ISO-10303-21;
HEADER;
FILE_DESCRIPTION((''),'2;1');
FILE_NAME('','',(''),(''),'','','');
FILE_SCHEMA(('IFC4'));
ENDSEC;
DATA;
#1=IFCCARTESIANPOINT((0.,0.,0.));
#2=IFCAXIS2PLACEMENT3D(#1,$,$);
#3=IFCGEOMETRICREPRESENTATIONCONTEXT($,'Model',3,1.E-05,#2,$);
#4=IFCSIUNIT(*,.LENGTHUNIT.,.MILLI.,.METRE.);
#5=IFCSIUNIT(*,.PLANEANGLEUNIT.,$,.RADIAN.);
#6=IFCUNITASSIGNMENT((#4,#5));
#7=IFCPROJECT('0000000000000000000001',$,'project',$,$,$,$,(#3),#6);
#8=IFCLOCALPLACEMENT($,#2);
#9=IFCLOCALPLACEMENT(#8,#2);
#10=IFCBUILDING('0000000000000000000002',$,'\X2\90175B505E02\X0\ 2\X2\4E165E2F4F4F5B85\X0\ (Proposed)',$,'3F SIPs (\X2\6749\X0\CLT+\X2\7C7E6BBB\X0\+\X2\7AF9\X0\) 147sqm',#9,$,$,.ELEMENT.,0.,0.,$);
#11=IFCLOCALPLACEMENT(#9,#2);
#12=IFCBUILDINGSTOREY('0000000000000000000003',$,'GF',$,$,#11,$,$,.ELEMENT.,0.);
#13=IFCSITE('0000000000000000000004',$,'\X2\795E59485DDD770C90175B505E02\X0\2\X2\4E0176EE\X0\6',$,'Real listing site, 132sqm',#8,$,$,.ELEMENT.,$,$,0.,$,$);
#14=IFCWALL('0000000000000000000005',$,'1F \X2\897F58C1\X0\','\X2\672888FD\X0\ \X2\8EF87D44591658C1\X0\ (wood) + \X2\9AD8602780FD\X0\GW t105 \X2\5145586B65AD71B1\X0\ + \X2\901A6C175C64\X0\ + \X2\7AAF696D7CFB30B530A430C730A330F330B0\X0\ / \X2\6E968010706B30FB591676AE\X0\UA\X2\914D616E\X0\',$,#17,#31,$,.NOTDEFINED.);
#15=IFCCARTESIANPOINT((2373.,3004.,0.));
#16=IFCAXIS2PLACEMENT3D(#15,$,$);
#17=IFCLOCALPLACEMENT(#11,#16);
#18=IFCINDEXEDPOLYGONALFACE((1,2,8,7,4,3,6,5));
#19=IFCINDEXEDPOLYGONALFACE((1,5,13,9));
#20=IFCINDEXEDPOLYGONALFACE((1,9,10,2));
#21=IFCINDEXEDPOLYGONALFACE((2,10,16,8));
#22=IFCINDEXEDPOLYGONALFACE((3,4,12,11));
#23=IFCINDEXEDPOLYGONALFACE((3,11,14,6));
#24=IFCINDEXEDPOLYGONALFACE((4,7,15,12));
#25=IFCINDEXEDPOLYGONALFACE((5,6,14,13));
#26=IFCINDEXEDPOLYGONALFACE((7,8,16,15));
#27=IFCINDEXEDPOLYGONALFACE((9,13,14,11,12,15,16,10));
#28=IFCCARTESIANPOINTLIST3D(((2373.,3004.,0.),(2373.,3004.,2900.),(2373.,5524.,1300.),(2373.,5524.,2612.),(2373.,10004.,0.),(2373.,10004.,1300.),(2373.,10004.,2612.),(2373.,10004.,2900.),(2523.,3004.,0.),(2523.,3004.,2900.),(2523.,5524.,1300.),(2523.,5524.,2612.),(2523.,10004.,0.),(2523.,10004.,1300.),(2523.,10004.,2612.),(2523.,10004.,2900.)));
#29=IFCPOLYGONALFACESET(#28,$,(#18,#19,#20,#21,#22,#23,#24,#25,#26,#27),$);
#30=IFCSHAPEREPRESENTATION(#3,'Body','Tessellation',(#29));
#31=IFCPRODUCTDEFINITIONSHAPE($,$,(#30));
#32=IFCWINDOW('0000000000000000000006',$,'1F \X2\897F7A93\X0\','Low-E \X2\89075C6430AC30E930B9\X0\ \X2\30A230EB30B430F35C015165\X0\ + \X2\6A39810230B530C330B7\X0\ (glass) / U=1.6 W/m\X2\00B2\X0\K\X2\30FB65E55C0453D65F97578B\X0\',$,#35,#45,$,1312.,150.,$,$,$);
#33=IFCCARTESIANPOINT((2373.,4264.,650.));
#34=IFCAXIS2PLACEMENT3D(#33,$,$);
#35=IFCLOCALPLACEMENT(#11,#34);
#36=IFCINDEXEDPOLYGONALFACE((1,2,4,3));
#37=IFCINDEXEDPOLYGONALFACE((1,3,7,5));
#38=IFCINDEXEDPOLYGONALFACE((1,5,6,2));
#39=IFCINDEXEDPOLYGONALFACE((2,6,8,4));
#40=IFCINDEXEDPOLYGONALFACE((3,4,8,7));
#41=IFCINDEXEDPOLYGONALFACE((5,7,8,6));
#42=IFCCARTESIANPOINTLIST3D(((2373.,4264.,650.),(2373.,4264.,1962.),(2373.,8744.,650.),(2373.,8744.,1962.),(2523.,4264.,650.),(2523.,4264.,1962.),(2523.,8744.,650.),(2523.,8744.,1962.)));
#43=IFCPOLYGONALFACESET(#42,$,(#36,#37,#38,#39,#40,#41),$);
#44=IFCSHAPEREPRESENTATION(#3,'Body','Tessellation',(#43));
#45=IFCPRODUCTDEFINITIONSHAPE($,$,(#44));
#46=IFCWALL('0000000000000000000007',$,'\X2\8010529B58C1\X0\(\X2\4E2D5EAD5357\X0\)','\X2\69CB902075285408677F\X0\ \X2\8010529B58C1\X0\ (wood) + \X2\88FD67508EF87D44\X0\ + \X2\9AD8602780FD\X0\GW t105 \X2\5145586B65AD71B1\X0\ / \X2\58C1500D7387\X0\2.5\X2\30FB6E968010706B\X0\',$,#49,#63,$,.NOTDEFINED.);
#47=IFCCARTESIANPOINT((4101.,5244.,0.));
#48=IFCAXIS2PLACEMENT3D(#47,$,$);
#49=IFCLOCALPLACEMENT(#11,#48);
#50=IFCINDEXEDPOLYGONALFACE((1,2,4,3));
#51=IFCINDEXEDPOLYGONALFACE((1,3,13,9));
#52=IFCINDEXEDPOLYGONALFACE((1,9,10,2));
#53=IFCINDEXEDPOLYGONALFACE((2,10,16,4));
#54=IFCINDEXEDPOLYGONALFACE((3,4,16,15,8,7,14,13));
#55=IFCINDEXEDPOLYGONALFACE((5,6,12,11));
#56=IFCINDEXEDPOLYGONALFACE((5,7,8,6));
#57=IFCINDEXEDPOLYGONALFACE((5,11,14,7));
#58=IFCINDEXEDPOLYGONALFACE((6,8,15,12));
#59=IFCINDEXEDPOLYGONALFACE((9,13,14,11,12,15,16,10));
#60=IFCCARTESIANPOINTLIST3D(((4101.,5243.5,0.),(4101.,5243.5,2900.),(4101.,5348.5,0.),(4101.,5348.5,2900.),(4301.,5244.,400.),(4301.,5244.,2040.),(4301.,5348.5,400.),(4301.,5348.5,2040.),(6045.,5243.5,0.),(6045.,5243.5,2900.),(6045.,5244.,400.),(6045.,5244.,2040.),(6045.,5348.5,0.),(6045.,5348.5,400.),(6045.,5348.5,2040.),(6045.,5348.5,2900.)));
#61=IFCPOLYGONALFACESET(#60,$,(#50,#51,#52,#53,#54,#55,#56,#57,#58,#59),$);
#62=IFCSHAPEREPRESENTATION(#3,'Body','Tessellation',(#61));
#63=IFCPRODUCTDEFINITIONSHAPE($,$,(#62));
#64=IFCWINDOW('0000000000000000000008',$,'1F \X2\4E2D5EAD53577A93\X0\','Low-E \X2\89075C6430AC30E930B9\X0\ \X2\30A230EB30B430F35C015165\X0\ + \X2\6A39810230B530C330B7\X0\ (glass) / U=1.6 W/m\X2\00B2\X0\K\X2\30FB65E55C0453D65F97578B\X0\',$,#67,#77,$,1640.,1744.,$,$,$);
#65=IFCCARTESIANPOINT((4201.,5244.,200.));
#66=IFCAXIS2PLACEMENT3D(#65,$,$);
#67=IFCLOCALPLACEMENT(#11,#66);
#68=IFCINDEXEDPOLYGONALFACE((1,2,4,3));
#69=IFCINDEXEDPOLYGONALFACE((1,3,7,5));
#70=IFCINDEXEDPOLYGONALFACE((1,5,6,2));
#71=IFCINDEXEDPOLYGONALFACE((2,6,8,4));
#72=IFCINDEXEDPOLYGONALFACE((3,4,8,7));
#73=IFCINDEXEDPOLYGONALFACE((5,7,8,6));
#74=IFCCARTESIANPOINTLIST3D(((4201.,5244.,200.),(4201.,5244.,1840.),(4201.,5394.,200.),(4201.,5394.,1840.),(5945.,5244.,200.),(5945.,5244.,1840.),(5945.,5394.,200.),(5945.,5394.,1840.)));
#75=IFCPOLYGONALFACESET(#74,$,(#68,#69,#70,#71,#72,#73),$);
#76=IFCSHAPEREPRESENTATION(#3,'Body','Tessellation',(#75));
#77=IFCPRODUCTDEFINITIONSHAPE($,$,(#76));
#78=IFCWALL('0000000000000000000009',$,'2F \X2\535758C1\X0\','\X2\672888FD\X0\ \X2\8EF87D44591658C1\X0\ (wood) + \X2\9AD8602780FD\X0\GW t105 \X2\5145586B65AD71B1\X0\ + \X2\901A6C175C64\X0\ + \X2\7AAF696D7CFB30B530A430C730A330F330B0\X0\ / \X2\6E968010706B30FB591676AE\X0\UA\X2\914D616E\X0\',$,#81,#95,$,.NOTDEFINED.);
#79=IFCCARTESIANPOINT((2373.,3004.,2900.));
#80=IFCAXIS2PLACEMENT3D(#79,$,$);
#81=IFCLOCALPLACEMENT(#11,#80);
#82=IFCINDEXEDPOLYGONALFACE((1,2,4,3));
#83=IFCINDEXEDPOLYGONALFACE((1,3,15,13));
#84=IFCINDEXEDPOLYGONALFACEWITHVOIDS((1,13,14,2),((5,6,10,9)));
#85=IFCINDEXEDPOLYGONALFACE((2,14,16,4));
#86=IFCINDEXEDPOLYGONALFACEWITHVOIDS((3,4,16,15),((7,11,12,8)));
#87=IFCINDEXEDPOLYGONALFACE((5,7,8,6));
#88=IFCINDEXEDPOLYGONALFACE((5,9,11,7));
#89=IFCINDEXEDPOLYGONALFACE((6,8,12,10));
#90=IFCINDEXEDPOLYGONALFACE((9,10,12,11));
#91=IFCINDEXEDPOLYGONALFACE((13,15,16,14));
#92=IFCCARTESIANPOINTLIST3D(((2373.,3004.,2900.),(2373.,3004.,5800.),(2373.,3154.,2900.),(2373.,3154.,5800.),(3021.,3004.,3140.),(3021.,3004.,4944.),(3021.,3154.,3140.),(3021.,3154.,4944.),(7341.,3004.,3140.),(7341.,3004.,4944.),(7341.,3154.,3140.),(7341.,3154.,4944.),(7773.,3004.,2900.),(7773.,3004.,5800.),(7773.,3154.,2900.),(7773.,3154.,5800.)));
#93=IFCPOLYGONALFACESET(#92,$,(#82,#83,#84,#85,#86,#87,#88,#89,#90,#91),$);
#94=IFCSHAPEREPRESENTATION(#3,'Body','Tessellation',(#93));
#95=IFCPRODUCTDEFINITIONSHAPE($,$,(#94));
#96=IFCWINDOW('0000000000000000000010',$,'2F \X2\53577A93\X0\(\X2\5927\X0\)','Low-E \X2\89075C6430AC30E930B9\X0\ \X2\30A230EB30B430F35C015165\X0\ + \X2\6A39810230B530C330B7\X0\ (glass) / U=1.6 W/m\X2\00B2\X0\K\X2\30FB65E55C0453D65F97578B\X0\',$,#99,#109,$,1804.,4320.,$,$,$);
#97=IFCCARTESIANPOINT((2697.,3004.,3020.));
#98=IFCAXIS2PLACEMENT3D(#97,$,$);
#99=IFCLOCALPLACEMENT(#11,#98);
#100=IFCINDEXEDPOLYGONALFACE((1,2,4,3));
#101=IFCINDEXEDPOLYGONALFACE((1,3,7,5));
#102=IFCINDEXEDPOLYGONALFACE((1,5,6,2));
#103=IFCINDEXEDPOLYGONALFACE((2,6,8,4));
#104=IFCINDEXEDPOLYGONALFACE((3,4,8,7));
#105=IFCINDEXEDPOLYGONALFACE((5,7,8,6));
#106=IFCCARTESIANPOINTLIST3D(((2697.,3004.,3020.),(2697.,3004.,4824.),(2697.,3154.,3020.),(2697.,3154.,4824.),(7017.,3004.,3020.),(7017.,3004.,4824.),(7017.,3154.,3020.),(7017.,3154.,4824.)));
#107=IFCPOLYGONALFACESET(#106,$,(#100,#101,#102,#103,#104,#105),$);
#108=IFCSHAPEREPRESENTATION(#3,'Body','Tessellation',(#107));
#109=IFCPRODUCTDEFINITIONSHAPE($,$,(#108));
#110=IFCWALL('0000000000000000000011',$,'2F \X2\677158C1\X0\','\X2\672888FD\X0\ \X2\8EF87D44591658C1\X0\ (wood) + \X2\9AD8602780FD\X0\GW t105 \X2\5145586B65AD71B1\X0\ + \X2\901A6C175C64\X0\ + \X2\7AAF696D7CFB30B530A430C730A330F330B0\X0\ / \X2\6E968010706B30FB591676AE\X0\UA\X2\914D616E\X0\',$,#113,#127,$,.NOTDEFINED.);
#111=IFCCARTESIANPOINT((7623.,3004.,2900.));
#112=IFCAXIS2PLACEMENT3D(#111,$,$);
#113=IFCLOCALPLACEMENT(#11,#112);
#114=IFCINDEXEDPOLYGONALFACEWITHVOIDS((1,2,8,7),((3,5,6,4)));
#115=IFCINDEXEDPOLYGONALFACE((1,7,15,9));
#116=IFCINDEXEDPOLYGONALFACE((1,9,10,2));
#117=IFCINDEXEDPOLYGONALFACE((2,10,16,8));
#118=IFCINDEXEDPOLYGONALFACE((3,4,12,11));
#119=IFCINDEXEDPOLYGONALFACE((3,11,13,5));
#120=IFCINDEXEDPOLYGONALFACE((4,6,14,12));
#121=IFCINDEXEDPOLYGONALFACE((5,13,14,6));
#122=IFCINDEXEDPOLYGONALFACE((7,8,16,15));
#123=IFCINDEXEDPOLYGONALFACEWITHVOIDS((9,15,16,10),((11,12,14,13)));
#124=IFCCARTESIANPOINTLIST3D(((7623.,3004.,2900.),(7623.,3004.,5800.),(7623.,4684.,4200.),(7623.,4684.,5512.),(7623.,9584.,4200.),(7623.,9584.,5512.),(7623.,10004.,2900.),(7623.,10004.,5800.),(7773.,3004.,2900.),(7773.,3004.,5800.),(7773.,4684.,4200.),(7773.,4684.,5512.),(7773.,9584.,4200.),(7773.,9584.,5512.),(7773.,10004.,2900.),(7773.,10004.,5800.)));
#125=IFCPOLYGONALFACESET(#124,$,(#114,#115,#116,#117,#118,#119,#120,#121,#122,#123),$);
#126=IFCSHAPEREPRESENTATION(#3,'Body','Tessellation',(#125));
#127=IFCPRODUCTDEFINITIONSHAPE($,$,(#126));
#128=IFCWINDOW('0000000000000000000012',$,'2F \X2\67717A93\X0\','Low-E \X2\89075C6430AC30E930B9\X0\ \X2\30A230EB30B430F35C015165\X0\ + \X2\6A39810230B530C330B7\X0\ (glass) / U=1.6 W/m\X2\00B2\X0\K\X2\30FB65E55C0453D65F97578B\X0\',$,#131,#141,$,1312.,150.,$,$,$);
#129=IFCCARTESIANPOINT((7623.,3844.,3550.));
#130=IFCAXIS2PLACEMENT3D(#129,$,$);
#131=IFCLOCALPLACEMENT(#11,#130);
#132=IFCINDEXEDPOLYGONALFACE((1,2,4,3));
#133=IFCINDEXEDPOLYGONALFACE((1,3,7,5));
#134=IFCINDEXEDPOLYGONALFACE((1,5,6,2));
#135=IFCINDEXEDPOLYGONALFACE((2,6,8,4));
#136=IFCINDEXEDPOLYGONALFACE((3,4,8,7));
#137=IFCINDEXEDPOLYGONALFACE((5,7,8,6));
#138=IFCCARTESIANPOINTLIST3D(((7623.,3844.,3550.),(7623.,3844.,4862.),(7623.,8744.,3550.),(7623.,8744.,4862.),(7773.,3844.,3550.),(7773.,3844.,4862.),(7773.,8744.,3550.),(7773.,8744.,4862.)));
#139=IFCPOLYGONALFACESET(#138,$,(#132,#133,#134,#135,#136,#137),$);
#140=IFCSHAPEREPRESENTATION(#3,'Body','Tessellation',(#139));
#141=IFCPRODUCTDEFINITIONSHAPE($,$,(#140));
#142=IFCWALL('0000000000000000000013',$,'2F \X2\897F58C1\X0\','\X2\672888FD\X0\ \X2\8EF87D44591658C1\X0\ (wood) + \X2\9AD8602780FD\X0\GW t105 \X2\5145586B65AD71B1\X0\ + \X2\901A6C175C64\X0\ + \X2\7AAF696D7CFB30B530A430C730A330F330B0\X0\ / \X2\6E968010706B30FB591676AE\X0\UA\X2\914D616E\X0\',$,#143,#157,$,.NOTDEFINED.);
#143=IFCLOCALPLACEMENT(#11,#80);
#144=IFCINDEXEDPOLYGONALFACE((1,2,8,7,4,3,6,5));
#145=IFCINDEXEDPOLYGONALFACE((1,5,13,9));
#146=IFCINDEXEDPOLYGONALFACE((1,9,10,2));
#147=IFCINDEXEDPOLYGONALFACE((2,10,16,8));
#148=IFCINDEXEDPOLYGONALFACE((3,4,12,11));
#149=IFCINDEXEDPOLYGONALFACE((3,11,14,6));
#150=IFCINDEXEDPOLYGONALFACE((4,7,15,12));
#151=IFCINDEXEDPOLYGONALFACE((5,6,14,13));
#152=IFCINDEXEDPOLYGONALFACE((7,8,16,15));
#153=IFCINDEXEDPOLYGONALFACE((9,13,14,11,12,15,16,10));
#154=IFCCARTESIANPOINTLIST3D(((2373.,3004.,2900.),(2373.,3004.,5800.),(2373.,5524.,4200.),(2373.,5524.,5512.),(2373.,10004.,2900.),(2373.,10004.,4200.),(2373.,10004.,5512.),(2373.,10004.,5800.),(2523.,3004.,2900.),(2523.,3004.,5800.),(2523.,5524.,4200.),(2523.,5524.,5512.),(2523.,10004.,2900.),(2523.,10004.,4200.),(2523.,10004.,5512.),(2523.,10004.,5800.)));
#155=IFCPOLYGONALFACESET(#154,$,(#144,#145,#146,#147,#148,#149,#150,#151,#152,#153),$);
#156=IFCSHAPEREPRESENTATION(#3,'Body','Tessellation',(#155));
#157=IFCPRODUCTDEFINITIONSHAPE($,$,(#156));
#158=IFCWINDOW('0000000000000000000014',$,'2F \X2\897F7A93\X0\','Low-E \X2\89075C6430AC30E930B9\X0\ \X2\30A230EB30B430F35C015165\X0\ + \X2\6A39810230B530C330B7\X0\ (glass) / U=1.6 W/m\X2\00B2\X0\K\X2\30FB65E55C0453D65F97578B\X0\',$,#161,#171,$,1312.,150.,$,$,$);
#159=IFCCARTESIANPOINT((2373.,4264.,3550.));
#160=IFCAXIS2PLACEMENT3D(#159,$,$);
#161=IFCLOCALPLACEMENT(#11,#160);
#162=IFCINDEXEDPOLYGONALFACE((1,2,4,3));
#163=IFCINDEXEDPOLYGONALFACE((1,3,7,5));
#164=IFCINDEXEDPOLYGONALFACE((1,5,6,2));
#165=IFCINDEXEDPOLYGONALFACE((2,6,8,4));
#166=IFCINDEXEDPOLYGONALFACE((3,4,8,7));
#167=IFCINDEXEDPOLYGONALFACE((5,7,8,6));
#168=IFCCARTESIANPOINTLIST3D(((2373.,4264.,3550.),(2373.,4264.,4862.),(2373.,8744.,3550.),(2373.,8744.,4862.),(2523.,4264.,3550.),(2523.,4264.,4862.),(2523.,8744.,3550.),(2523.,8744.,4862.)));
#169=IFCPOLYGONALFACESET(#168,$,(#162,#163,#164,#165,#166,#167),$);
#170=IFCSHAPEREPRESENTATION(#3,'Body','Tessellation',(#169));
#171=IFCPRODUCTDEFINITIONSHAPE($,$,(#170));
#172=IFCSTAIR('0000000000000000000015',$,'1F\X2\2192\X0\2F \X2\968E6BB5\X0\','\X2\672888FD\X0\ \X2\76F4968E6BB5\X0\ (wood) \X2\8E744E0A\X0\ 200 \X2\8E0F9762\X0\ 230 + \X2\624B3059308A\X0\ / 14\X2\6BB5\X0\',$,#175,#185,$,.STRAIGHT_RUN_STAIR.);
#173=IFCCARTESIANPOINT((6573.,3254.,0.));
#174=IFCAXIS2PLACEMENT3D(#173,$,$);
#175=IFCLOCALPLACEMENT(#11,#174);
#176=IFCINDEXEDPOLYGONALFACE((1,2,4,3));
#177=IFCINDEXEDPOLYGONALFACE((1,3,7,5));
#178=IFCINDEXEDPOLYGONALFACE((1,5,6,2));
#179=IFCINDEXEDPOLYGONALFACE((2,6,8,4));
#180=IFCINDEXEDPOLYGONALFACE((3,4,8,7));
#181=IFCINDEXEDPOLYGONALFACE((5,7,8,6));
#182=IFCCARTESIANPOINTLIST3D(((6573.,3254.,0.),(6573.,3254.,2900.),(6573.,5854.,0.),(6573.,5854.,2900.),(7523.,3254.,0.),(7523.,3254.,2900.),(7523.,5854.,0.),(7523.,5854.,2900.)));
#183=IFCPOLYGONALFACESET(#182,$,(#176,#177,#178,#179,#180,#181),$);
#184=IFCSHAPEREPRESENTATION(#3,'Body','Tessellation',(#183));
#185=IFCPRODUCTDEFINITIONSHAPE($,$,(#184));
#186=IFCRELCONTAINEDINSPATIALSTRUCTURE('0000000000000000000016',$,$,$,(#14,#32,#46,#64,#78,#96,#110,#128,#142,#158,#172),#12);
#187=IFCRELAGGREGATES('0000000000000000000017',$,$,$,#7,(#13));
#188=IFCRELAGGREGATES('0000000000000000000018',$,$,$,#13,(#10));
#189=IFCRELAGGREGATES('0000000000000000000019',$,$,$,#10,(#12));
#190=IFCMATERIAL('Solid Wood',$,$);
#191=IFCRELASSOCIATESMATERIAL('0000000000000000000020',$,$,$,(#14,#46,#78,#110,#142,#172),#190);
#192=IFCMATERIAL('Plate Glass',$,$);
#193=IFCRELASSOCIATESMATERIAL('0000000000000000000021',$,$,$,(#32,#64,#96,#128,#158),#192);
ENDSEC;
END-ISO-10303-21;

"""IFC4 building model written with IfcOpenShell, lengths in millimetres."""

from ifc_helpers import new_model, si_unit, frame, frame_2d, origin, place, context, project, spatial, rectangle, extrude, material, element, fill, save


model = new_model("IFC4")

# Units and contexts
model_context = context("Model", 3, precision=1e-05, world=origin())
ifc_project = project(units=[si_unit("LENGTHUNIT", "METRE", prefix="MILLI"), si_unit("PLANEANGLEUNIT", "RADIAN")], contexts=[model_context])

# Site, building, storey
site_placement = place(None, origin())
site = spatial("IfcSite", under=ifc_project, at=site_placement, Name="神奈川県逗子市2丁目6", ObjectType="Real listing site, 132sqm", CompositionType="ELEMENT", RefElevation=0.0)
building_placement = place(site_placement, origin())
building = spatial("IfcBuilding", under=site, at=building_placement, Name="逗子市 2世帯住宅 (Proposed)", ObjectType="3F SIPs (杉CLT+籾殻+竹) 147sqm", CompositionType="ELEMENT", ElevationOfRefHeight=0.0, ElevationOfTerrain=0.0)
storey_placement = place(building_placement, origin())
storey = spatial("IfcBuildingStorey", under=building, at=storey_placement, Name="GF", CompositionType="ELEMENT", Elevation=0.0)

# Shared definitions
ifc_material_1 = material(Name="Solid Wood")

# Shared definitions
ifc_material_2 = material(Name="Plate Glass")

# Walls, openings, windows
wall_1_placement = place(storey_placement, frame((2373.0, 3004.0, 0.0)))
wall_1 = element("IfcWall", 1, at=wall_1_placement, inside=storey, material=ifc_material_1, Name="1F 西壁", Description="木製 軸組外壁 (wood) + 高性能GW t105 充填断熱 + 通気層 + 窯業系サイディング / 準耐火・外皮UA配慮", PredefinedType="NOTDEFINED", context=model_context, shape_type="SweptSolid", body=[
    extrude(rectangle(XDim=150.0, YDim=7000.0, at=frame_2d((75.0, 3500.0))), frame((2373.0, 3004.0, 0.0)), (0.0, 0.0, 1.0), 2900.0),
])
opening_1_placement = place(storey_placement, frame((2373.0, 4264.0, 650.0)))
opening_1 = element("IfcOpeningElement", 2, at=opening_1_placement, cuts=wall_1, PredefinedType="NOTDEFINED", context=model_context, shape_type="SweptSolid", body=[
    extrude(rectangle(XDim=150.0, YDim=4480.0, at=frame_2d((75.0, 2240.0))), frame((2373.0, 4264.0, 650.0)), (0.0, 0.0, 1.0), 1312.0),
])
window_1_placement = place(storey_placement, frame((2373.0, 4264.0, 650.0)))
window_1 = element("IfcWindow", 3, at=window_1_placement, inside=storey, material=ifc_material_2, Name="1F 西窓", Description="Low-E 複層ガラス アルゴン封入 + 樹脂サッシ (glass) / U=1.6 W/m²K・日射取得型", OverallHeight=1312.0, OverallWidth=150.0, context=model_context, shape_type="SweptSolid", body=[
    extrude(rectangle(XDim=150.0, YDim=4480.0, at=frame_2d((75.0, 2240.0))), frame((2373.0, 4264.0, 650.0)), (0.0, 0.0, 1.0), 1312.0),
])
fill(opening_1, window_1)
wall_2_placement = place(storey_placement, frame((4101.0, 5244.0, 0.0)))
wall_2 = element("IfcWall", 4, at=wall_2_placement, inside=storey, material=ifc_material_1, Name="耐力壁(中庭南)", Description="構造用合板 耐力壁 (wood) + 製材軸組 + 高性能GW t105 充填断熱 / 壁倍率2.5・準耐火", PredefinedType="NOTDEFINED", context=model_context, shape_type="SweptSolid", body=[
    extrude(rectangle(XDim=1944.0, YDim=105.0, at=frame_2d((972.0, 52.0))), frame((4101.0, 5244.0, 0.0)), (0.0, 0.0, 1.0), 2900.0),
])
opening_2_placement = place(storey_placement, frame((4201.0, 5244.0, 200.0)))
opening_2 = element("IfcOpeningElement", 5, at=opening_2_placement, cuts=wall_2, PredefinedType="NOTDEFINED", context=model_context, shape_type="SweptSolid", body=[
    extrude(rectangle(XDim=1744.0, YDim=150.0, at=frame_2d((872.0, 75.0))), frame((4201.0, 5244.0, 200.0)), (0.0, 0.0, 1.0), 1640.0),
])
window_2_placement = place(storey_placement, frame((4201.0, 5244.0, 200.0)))
window_2 = element("IfcWindow", 6, at=window_2_placement, inside=storey, material=ifc_material_2, Name="1F 中庭南窓", Description="Low-E 複層ガラス アルゴン封入 + 樹脂サッシ (glass) / U=1.6 W/m²K・日射取得型", OverallHeight=1640.0, OverallWidth=1744.0, context=model_context, shape_type="SweptSolid", body=[
    extrude(rectangle(XDim=1744.0, YDim=150.0, at=frame_2d((872.0, 75.0))), frame((4201.0, 5244.0, 200.0)), (0.0, 0.0, 1.0), 1640.0),
])
fill(opening_2, window_2)
wall_3_placement = place(storey_placement, frame((2373.0, 3004.0, 2900.0)))
wall_3 = element("IfcWall", 7, at=wall_3_placement, inside=storey, material=ifc_material_1, Name="2F 南壁", Description="木製 軸組外壁 (wood) + 高性能GW t105 充填断熱 + 通気層 + 窯業系サイディング / 準耐火・外皮UA配慮", PredefinedType="NOTDEFINED", context=model_context, shape_type="SweptSolid", body=[
    extrude(rectangle(XDim=5400.0, YDim=150.0, at=frame_2d((2700.0, 75.0))), frame((2373.0, 3004.0, 2900.0)), (0.0, 0.0, 1.0), 2900.0),
])
opening_3_placement = place(storey_placement, frame((2697.0, 3004.0, 3020.0)))
opening_3 = element("IfcOpeningElement", 8, at=opening_3_placement, cuts=wall_3, PredefinedType="NOTDEFINED", context=model_context, shape_type="SweptSolid", body=[
    extrude(rectangle(XDim=4320.0, YDim=150.0, at=frame_2d((2160.0, 75.0))), frame((2697.0, 3004.0, 3020.0)), (0.0, 0.0, 1.0), 1804.0),
])
window_3_placement = place(storey_placement, frame((2697.0, 3004.0, 3020.0)))
window_3 = element("IfcWindow", 9, at=window_3_placement, inside=storey, material=ifc_material_2, Name="2F 南窓(大)", Description="Low-E 複層ガラス アルゴン封入 + 樹脂サッシ (glass) / U=1.6 W/m²K・日射取得型", OverallHeight=1804.0, OverallWidth=4320.0, context=model_context, shape_type="SweptSolid", body=[
    extrude(rectangle(XDim=4320.0, YDim=150.0, at=frame_2d((2160.0, 75.0))), frame((2697.0, 3004.0, 3020.0)), (0.0, 0.0, 1.0), 1804.0),
])
fill(opening_3, window_3)
wall_4_placement = place(storey_placement, frame((7623.0, 3004.0, 2900.0)))
wall_4 = element("IfcWall", 10, at=wall_4_placement, inside=storey, material=ifc_material_1, Name="2F 東壁", Description="木製 軸組外壁 (wood) + 高性能GW t105 充填断熱 + 通気層 + 窯業系サイディング / 準耐火・外皮UA配慮", PredefinedType="NOTDEFINED", context=model_context, shape_type="SweptSolid", body=[
    extrude(rectangle(XDim=150.0, YDim=7000.0, at=frame_2d((75.0, 3500.0))), frame((7623.0, 3004.0, 2900.0)), (0.0, 0.0, 1.0), 2900.0),
])
opening_4_placement = place(storey_placement, frame((7623.0, 3844.0, 3550.0)))
opening_4 = element("IfcOpeningElement", 11, at=opening_4_placement, cuts=wall_4, PredefinedType="NOTDEFINED", context=model_context, shape_type="SweptSolid", body=[
    extrude(rectangle(XDim=150.0, YDim=4900.0, at=frame_2d((75.0, 2450.0))), frame((7623.0, 3844.0, 3550.0)), (0.0, 0.0, 1.0), 1312.0),
])
window_4_placement = place(storey_placement, frame((7623.0, 3844.0, 3550.0)))
window_4 = element("IfcWindow", 12, at=window_4_placement, inside=storey, material=ifc_material_2, Name="2F 東窓", Description="Low-E 複層ガラス アルゴン封入 + 樹脂サッシ (glass) / U=1.6 W/m²K・日射取得型", OverallHeight=1312.0, OverallWidth=150.0, context=model_context, shape_type="SweptSolid", body=[
    extrude(rectangle(XDim=150.0, YDim=4900.0, at=frame_2d((75.0, 2450.0))), frame((7623.0, 3844.0, 3550.0)), (0.0, 0.0, 1.0), 1312.0),
])
fill(opening_4, window_4)
wall_5_placement = place(storey_placement, frame((2373.0, 3004.0, 2900.0)))
wall_5 = element("IfcWall", 13, at=wall_5_placement, inside=storey, material=ifc_material_1, Name="2F 西壁", Description="木製 軸組外壁 (wood) + 高性能GW t105 充填断熱 + 通気層 + 窯業系サイディング / 準耐火・外皮UA配慮", PredefinedType="NOTDEFINED", context=model_context, shape_type="SweptSolid", body=[
    extrude(rectangle(XDim=150.0, YDim=7000.0, at=frame_2d((75.0, 3500.0))), frame((2373.0, 3004.0, 2900.0)), (0.0, 0.0, 1.0), 2900.0),
])
opening_5_placement = place(storey_placement, frame((2373.0, 4264.0, 3550.0)))
opening_5 = element("IfcOpeningElement", 14, at=opening_5_placement, cuts=wall_5, PredefinedType="NOTDEFINED", context=model_context, shape_type="SweptSolid", body=[
    extrude(rectangle(XDim=150.0, YDim=4480.0, at=frame_2d((75.0, 2240.0))), frame((2373.0, 4264.0, 3550.0)), (0.0, 0.0, 1.0), 1312.0),
])
window_5_placement = place(storey_placement, frame((2373.0, 4264.0, 3550.0)))
window_5 = element("IfcWindow", 15, at=window_5_placement, inside=storey, material=ifc_material_2, Name="2F 西窓", Description="Low-E 複層ガラス アルゴン封入 + 樹脂サッシ (glass) / U=1.6 W/m²K・日射取得型", OverallHeight=1312.0, OverallWidth=150.0, context=model_context, shape_type="SweptSolid", body=[
    extrude(rectangle(XDim=150.0, YDim=4480.0, at=frame_2d((75.0, 2240.0))), frame((2373.0, 4264.0, 3550.0)), (0.0, 0.0, 1.0), 1312.0),
])
fill(opening_5, window_5)

# Stair
stair_1_placement = place(storey_placement, frame((6573.0, 3254.0, 0.0)))
element("IfcStair", 16, at=stair_1_placement, inside=storey, material=ifc_material_1, Name="1F→2F 階段", Description="木製 直階段 (wood) 蹴上 200 踏面 230 + 手すり / 14段", PredefinedType="STRAIGHT_RUN_STAIR", context=model_context, shape_type="SweptSolid", body=[
    extrude(rectangle(XDim=950.0, YDim=2600.0, at=frame_2d((475.0, 1300.0))), frame((6573.0, 3254.0, 0.0)), (0.0, 0.0, 1.0), 2900.0),
])

save(model, "model.ifc")
